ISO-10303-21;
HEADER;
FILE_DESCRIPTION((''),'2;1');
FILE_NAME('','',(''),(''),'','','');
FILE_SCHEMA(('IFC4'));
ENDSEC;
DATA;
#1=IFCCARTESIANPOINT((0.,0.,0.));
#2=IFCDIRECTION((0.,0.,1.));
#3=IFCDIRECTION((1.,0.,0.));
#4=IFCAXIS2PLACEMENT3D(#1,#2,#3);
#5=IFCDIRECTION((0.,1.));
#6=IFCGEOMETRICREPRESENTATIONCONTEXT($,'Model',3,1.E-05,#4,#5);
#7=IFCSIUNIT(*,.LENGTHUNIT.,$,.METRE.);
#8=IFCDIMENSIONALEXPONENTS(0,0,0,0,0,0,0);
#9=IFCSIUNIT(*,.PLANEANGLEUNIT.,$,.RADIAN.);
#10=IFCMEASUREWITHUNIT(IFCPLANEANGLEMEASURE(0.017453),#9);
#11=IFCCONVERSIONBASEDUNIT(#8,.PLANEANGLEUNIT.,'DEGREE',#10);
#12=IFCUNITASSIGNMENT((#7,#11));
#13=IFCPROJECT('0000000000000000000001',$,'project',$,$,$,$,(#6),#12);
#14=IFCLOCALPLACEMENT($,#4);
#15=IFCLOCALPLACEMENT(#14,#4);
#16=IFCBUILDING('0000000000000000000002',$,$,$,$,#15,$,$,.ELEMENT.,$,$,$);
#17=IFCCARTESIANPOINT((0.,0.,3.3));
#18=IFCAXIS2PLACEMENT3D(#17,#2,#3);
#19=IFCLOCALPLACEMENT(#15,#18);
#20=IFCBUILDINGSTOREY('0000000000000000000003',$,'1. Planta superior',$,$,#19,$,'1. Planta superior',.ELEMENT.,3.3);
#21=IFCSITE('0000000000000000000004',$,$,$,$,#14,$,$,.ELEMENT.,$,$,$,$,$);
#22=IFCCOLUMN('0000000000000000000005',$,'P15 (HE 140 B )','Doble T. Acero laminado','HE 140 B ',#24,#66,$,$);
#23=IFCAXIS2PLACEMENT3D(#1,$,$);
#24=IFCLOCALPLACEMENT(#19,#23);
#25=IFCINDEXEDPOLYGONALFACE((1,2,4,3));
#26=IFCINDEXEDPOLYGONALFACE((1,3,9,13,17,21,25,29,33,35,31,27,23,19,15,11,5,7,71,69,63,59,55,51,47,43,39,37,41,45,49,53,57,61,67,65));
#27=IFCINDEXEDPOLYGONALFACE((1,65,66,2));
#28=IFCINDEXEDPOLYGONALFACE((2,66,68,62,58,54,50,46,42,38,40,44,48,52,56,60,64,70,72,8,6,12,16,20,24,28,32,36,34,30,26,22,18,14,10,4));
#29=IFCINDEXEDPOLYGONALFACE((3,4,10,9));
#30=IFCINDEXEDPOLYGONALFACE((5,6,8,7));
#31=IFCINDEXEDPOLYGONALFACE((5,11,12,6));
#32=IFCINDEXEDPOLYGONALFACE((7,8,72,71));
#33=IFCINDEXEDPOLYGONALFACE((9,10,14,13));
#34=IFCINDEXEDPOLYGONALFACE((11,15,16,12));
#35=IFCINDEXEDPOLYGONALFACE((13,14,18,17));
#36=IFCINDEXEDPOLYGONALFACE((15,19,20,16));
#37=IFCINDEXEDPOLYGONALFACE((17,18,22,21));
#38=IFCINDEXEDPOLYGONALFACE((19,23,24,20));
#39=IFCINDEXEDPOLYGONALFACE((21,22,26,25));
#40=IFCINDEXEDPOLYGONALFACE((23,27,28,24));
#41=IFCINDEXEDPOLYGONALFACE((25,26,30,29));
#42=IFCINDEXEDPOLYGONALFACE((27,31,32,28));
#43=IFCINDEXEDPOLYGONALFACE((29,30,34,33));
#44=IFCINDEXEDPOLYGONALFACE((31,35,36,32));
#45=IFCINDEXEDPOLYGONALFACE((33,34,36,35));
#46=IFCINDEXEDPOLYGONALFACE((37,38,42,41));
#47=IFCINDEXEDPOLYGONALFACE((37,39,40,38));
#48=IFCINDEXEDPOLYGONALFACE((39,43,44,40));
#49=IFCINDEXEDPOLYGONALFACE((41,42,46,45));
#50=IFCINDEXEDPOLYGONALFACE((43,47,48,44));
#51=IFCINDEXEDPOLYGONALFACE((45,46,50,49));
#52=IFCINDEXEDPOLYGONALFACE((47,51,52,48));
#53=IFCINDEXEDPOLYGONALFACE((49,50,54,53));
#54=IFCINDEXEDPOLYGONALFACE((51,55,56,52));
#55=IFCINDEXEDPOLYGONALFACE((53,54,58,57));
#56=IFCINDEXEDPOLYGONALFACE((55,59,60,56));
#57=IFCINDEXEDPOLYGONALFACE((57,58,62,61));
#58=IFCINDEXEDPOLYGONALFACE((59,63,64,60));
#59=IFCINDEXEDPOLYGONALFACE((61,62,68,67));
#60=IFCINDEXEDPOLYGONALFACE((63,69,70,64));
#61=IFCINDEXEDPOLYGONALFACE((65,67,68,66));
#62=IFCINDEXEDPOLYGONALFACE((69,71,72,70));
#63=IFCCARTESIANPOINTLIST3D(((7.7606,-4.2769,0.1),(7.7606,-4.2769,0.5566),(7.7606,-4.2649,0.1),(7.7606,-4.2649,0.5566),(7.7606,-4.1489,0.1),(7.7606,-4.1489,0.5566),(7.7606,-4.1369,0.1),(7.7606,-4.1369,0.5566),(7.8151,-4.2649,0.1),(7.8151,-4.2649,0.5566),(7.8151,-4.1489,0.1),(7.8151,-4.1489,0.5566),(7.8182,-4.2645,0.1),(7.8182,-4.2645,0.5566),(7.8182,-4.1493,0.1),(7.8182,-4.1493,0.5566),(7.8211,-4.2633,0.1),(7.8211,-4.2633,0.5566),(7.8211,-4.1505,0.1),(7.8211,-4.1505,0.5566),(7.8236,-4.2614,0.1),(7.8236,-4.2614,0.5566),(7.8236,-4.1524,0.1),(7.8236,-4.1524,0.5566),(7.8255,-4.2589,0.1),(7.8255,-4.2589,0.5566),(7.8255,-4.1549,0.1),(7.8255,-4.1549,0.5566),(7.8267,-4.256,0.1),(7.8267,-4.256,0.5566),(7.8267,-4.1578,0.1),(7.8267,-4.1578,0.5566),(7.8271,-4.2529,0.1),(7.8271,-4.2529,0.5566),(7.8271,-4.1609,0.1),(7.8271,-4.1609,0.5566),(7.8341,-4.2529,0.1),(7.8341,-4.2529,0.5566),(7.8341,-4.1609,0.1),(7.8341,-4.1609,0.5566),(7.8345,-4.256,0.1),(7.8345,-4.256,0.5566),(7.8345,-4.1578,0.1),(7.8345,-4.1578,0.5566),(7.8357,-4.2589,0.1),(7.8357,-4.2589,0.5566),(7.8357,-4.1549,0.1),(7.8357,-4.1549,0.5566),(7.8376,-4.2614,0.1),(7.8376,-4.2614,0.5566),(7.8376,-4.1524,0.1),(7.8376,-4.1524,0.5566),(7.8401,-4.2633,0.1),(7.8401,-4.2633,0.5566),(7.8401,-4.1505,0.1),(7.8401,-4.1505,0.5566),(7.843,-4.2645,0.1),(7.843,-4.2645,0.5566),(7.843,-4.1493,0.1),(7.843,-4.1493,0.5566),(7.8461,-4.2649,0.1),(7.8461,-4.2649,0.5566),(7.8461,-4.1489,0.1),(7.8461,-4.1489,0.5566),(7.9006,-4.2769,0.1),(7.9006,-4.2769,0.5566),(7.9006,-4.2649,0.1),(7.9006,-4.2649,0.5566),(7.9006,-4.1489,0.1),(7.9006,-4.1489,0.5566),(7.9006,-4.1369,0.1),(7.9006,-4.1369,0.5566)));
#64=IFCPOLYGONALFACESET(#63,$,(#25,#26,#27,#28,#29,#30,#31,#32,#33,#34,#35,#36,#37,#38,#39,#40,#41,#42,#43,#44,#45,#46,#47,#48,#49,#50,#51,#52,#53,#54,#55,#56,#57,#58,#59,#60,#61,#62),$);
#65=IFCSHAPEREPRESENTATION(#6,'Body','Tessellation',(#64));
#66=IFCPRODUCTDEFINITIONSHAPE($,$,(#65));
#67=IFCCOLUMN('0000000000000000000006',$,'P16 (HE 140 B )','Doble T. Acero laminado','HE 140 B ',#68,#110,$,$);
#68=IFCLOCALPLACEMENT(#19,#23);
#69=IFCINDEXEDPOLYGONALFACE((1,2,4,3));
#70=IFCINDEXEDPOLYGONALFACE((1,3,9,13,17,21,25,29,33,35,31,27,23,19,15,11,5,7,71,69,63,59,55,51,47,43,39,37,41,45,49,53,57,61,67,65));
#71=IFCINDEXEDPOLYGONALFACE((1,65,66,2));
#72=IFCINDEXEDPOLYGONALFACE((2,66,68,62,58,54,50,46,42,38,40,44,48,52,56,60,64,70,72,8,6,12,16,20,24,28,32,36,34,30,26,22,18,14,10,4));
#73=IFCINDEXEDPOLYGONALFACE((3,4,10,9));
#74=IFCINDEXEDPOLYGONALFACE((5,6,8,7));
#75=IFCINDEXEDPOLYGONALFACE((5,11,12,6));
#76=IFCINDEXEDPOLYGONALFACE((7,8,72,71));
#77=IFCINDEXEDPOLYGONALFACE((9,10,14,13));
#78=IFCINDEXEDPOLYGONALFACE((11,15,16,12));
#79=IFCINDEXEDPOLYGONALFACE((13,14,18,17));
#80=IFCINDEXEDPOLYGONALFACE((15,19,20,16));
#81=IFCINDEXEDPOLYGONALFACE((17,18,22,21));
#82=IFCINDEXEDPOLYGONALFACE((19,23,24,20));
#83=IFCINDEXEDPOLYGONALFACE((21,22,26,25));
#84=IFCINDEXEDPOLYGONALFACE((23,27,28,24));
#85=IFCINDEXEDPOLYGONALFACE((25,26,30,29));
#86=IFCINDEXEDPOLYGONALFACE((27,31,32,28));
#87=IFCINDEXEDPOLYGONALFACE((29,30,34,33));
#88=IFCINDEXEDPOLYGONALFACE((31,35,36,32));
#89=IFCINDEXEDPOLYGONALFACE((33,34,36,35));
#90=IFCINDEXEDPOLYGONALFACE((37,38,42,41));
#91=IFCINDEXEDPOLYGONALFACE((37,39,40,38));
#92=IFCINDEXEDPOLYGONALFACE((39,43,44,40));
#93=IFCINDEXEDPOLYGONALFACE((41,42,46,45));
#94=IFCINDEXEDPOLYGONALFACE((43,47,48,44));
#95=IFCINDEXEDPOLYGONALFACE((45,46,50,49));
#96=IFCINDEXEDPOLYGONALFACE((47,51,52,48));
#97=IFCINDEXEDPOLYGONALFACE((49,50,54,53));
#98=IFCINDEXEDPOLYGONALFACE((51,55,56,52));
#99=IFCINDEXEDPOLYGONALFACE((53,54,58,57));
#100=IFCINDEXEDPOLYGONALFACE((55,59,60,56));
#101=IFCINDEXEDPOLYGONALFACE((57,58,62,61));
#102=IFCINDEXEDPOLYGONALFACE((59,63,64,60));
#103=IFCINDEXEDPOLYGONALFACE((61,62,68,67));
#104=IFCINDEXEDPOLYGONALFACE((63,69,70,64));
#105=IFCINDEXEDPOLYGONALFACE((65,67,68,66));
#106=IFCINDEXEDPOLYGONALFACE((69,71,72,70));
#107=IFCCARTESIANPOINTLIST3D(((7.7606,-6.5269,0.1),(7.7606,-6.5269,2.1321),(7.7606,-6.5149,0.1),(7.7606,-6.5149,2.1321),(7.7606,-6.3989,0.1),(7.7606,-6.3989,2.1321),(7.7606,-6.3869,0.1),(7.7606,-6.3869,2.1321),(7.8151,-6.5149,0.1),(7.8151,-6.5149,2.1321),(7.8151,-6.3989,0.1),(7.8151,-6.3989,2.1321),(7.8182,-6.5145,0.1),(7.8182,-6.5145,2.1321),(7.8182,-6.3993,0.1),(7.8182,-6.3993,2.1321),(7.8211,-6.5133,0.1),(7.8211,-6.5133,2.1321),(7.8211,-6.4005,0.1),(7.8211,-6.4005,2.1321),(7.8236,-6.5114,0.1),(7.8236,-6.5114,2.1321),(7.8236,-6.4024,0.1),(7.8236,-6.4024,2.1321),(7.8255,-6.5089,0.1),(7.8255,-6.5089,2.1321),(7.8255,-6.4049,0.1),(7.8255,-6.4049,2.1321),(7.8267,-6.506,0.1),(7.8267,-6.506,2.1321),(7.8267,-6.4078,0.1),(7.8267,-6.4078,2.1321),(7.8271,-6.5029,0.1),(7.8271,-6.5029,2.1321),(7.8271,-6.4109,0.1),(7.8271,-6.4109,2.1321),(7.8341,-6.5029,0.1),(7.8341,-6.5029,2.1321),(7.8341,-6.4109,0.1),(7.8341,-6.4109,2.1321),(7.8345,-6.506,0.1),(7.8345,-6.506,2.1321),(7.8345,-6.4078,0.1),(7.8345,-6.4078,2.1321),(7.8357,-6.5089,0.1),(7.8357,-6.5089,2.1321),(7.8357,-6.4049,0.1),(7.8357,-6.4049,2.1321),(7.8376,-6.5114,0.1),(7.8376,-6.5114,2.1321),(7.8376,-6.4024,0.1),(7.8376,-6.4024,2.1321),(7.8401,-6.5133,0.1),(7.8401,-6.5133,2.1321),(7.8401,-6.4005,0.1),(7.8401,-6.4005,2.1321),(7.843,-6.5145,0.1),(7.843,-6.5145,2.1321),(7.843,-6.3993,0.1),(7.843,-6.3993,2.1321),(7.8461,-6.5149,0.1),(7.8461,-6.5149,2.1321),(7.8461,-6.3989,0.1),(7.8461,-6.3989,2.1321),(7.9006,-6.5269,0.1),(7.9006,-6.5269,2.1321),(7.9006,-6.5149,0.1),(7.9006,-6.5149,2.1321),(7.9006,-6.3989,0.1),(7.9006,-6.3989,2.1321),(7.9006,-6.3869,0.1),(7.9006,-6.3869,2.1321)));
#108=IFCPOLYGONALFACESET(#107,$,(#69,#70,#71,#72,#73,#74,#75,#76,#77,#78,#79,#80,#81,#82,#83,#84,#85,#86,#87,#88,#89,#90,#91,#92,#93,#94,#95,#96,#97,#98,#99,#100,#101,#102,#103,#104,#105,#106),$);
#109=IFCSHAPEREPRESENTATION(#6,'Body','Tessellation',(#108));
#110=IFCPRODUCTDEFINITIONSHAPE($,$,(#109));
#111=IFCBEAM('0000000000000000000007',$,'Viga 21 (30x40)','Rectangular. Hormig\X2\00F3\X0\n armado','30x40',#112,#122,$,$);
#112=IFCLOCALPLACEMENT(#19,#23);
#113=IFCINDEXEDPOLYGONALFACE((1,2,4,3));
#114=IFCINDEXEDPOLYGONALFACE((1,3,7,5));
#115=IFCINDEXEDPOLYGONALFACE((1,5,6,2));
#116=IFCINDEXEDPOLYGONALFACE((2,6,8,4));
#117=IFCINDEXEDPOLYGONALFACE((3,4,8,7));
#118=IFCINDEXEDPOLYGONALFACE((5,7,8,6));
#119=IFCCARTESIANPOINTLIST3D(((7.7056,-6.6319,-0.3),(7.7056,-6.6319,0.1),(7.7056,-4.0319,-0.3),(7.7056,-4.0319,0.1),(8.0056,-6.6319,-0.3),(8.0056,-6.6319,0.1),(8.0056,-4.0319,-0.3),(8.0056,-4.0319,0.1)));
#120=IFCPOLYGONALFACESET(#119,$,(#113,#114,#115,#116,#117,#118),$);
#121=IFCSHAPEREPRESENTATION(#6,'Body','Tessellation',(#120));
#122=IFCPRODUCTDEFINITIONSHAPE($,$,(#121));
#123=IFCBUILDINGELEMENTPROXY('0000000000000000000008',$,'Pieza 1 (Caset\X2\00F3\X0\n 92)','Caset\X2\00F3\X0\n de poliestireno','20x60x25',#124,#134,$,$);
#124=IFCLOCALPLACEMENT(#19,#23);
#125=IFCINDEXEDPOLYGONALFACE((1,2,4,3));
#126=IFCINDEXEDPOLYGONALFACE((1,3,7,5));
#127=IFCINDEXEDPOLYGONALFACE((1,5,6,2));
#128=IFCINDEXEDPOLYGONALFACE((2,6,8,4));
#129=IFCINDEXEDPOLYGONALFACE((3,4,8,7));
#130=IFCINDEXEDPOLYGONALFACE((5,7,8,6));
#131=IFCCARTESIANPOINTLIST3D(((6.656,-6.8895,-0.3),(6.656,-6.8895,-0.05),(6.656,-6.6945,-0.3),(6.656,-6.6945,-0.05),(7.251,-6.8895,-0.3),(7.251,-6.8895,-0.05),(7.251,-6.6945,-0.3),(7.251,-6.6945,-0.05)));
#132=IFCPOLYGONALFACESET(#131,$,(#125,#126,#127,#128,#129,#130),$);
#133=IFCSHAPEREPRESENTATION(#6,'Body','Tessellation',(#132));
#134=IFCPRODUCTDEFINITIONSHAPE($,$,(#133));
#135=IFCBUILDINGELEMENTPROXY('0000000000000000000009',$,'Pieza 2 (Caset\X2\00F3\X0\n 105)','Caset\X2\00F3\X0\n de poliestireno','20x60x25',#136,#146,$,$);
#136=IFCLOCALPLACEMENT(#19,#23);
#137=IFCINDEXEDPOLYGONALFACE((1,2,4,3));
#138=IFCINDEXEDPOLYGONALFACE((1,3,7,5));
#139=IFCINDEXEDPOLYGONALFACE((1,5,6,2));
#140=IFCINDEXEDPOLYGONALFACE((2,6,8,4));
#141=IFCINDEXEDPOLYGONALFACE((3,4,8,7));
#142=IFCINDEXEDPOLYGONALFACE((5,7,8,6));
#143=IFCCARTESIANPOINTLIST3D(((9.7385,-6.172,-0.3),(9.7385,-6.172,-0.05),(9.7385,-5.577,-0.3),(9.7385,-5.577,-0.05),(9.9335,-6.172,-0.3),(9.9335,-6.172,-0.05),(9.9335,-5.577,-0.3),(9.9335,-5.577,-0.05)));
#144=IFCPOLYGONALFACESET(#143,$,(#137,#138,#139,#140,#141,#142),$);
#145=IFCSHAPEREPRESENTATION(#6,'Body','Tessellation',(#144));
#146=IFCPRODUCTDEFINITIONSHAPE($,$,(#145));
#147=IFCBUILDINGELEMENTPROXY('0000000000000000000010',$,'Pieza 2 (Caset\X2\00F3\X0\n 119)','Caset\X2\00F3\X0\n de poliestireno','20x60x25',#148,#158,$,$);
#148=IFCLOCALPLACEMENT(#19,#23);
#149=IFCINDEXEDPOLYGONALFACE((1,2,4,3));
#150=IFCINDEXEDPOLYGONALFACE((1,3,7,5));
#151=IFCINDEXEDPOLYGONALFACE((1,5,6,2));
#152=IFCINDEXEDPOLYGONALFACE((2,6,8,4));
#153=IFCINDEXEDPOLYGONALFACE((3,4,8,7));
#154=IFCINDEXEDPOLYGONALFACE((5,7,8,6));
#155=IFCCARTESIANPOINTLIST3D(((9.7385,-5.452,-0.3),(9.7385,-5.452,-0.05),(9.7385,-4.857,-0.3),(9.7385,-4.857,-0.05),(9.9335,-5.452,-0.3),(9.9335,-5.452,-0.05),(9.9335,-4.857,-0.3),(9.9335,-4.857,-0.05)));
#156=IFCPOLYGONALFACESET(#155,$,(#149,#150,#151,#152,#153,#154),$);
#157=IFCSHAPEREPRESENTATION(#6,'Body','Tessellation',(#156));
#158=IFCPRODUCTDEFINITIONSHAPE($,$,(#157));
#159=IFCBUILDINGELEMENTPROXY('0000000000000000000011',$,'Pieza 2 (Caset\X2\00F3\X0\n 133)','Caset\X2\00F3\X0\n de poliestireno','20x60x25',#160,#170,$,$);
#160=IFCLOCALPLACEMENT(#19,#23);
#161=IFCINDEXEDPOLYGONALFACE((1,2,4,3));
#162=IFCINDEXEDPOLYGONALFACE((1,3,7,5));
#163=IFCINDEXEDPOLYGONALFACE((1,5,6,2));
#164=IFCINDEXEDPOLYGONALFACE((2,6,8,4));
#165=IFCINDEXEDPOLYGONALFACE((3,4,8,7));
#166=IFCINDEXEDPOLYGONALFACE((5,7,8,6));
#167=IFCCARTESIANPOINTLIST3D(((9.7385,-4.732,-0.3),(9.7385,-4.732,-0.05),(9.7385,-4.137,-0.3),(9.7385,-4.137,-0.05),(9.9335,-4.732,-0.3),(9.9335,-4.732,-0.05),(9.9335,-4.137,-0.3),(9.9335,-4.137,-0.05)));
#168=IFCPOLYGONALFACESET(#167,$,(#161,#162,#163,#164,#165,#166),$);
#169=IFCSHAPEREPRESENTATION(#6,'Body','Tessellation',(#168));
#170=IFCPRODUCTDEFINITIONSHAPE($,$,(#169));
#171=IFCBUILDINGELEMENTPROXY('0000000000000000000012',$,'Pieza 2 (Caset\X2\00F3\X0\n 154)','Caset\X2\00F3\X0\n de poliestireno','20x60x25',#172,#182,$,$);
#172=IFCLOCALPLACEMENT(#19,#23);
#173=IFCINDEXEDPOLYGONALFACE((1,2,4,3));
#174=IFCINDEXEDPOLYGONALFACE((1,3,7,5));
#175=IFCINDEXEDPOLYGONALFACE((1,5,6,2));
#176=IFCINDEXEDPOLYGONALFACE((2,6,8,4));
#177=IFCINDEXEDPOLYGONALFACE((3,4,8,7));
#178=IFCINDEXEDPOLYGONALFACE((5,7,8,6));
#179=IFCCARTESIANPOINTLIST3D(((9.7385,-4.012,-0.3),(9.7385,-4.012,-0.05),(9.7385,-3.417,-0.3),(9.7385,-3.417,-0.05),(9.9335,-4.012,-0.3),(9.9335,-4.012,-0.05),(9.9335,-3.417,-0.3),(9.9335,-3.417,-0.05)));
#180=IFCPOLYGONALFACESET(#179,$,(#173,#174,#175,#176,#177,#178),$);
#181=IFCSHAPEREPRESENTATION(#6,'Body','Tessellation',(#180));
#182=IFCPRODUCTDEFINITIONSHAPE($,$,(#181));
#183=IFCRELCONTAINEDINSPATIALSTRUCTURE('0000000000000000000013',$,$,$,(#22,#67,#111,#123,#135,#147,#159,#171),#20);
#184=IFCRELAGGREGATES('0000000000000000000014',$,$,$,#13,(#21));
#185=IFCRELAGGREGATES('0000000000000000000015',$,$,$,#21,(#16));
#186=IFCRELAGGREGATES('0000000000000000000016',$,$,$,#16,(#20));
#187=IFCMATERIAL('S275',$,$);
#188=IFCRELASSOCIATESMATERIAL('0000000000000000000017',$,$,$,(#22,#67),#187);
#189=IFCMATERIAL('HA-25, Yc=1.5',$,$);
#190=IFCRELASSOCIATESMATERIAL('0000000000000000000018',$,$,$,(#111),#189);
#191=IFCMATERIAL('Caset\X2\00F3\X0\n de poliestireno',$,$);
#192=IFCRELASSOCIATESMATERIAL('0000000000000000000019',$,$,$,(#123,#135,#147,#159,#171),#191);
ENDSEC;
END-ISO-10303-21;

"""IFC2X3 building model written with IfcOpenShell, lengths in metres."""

from ifc_helpers import new_model, entity, si_unit, converted_unit, direction, frame, frame_2d, origin_with_axes, origin_2d_with_axis, place, context, project, spatial, rectangle, i_section, extrude, source, transform, mapped, material, element, save


model = new_model("IFC2X3")

# Units and contexts
model_context = context("Model", 3, precision=1e-05, world=origin_with_axes(), true_north=direction((0.0, 1.0)))
ifc_project = project(units=[si_unit("LENGTHUNIT", "METRE"), converted_unit("PLANEANGLEUNIT", "DEGREE", entity("IfcPlaneAngleMeasure", 0.017453), si_unit("PLANEANGLEUNIT", "RADIAN"), dimensions=[0, 0, 0, 0, 0, 0, 0])], contexts=[model_context])

# Site, building, storey
site_placement = place(None, origin_with_axes())
site = spatial("IfcSite", under=ifc_project, at=site_placement, CompositionType="ELEMENT")
building_placement = place(site_placement, origin_with_axes())
building = spatial("IfcBuilding", under=site, at=building_placement, CompositionType="ELEMENT")
storey_placement = place(building_placement, frame((0.0, 0.0, 3.3), z_axis=(0.0, 0.0, 1.0), x_axis=(1.0, 0.0, 0.0)))
storey = spatial("IfcBuildingStorey", under=building, at=storey_placement, Name="1. Planta superior", LongName="1. Planta superior", CompositionType="ELEMENT", Elevation=3.3)

# Columns
ifc_material_1 = material(Name="S275")
column_1_placement = place(storey_placement, frame((7.8306, -4.2069, 0.1), z_axis=(0.0, 0.0, 1.0), x_axis=(1.0, 0.0, 0.0)))
element("IfcColumn", 1, at=column_1_placement, inside=storey, material=ifc_material_1, Name="P15 (HE 140 B )", Description="Doble T. Acero laminado", ObjectType="HE 140 B ", context=model_context, shape_type="SweptSolid", body=[
    extrude(i_section(OverallWidth=0.14, OverallDepth=0.14, WebThickness=0.007, FlangeThickness=0.012, FilletRadius=0.012, at=origin_2d_with_axis()), origin_with_axes(), (0.0, 0.0, 1.0), 0.4566),
])
column_2_placement = place(storey_placement, frame((7.8306, -6.4569, 0.1), z_axis=(0.0, 0.0, 1.0), x_axis=(1.0, 0.0, 0.0)))
element("IfcColumn", 2, at=column_2_placement, inside=storey, material=ifc_material_1, Name="P16 (HE 140 B )", Description="Doble T. Acero laminado", ObjectType="HE 140 B ", context=model_context, shape_type="SweptSolid", body=[
    extrude(i_section(OverallWidth=0.14, OverallDepth=0.14, WebThickness=0.007, FlangeThickness=0.012, FilletRadius=0.012, at=origin_2d_with_axis()), origin_with_axes(), (0.0, 0.0, 1.0), 2.0321),
])

# Beam
ifc_material_2 = material(Name="HA-25, Yc=1.5")
beam_placement = place(storey_placement, frame((7.8556, -6.6319, 0.1), z_axis=(0.0, 1.0, 0.0), x_axis=(-1.0, 0.0, 0.0)))
element("IfcBeam", 3, at=beam_placement, inside=storey, material=ifc_material_2, Name="Viga 21 (30x40)", Description="Rectangular. Hormigón armado", ObjectType="30x40", context=model_context, shape_type="SweptSolid", body=[
    extrude(rectangle(XDim=0.3, YDim=0.4, at=frame_2d((0.0, -0.2), x_axis=(1.0, 0.0))), origin_with_axes(), (0.0, 0.0, 1.0), 2.6),
])

# Building element proxies
ifc_material_3 = material(Name="Casetón de poliestireno")
shared_shape = source(origin_with_axes(), model_context, "Body", "SweptSolid", [
    extrude(rectangle(XDim=0.195, YDim=0.25, at=origin_2d_with_axis()), origin_with_axes(), (0.0, 0.0, 1.0), 0.595),
])
placement_1 = place(storey_placement, frame((6.656, -6.792, -0.175), z_axis=(1.0, 0.0, 0.0), x_axis=(0.0, 1.0, 0.0)))
proxy_placement = place(placement_1, origin_with_axes())
element("IfcBuildingElementProxy", 4, at=proxy_placement, inside=storey, material=ifc_material_3, Name="Pieza 1 (Casetón 92)", Description="Casetón de poliestireno", ObjectType="20x60x25", context=model_context, shape_type="MappedRepresentation", body=[
    mapped(shared_shape, transform((0.0, 0.0, 0.0), x_axis=(1.0, 0.0, 0.0), y_axis=(0.0, 1.0, 0.0), z_axis=(0.0, 0.0, 1.0))),
])
placement_2 = place(storey_placement, frame((9.836, -6.172, -0.175), z_axis=(0.0, 1.0, 0.0), x_axis=(-1.0, 0.0, 0.0)))
for number, where, z_axis, x_axis, name in (
    (5, (0.0, 0.0, 0.0), (0.0, 0.0, 1.0), (1.0, 0.0, 0.0), "Pieza 2 (Casetón 105)"),
):
    element("IfcBuildingElementProxy", number, at=place(placement_2, frame(where, z_axis=z_axis, x_axis=x_axis)), inside=storey, material=ifc_material_3, Name=name, Description="Casetón de poliestireno", ObjectType="20x60x25", context=model_context, shape_type="MappedRepresentation", body=[
        mapped(shared_shape, transform((0.0, 0.0, 0.0), x_axis=(1.0, 0.0, 0.0), y_axis=(0.0, 1.0, 0.0), z_axis=(0.0, 0.0, 1.0))),
    ])
placement_3 = place(storey_placement, frame((9.836, -5.452, -0.175), z_axis=(0.0, 1.0, 0.0), x_axis=(-1.0, 0.0, 0.0)))
for number, where, z_axis, x_axis, name in (
    (6, (0.0, 0.0, 0.0), (0.0, 0.0, 1.0), (1.0, 0.0, 0.0), "Pieza 2 (Casetón 119)"),
):
    element("IfcBuildingElementProxy", number, at=place(placement_3, frame(where, z_axis=z_axis, x_axis=x_axis)), inside=storey, material=ifc_material_3, Name=name, Description="Casetón de poliestireno", ObjectType="20x60x25", context=model_context, shape_type="MappedRepresentation", body=[
        mapped(shared_shape, transform((0.0, 0.0, 0.0), x_axis=(1.0, 0.0, 0.0), y_axis=(0.0, 1.0, 0.0), z_axis=(0.0, 0.0, 1.0))),
    ])
placement_4 = place(storey_placement, frame((9.836, -4.732, -0.175), z_axis=(0.0, 1.0, 0.0), x_axis=(-1.0, 0.0, 0.0)))
for number, where, z_axis, x_axis, name in (
    (7, (0.0, 0.0, 0.0), (0.0, 0.0, 1.0), (1.0, 0.0, 0.0), "Pieza 2 (Casetón 133)"),
):
    element("IfcBuildingElementProxy", number, at=place(placement_4, frame(where, z_axis=z_axis, x_axis=x_axis)), inside=storey, material=ifc_material_3, Name=name, Description="Casetón de poliestireno", ObjectType="20x60x25", context=model_context, shape_type="MappedRepresentation", body=[
        mapped(shared_shape, transform((0.0, 0.0, 0.0), x_axis=(1.0, 0.0, 0.0), y_axis=(0.0, 1.0, 0.0), z_axis=(0.0, 0.0, 1.0))),
    ])
placement_5 = place(storey_placement, frame((9.836, -4.012, -0.175), z_axis=(0.0, 1.0, 0.0), x_axis=(-1.0, 0.0, 0.0)))
for number, where, z_axis, x_axis, name in (
    (8, (0.0, 0.0, 0.0), (0.0, 0.0, 1.0), (1.0, 0.0, 0.0), "Pieza 2 (Casetón 154)"),
):
    element("IfcBuildingElementProxy", number, at=place(placement_5, frame(where, z_axis=z_axis, x_axis=x_axis)), inside=storey, material=ifc_material_3, Name=name, Description="Casetón de poliestireno", ObjectType="20x60x25", context=model_context, shape_type="MappedRepresentation", body=[
        mapped(shared_shape, transform((0.0, 0.0, 0.0), x_axis=(1.0, 0.0, 0.0), y_axis=(0.0, 1.0, 0.0), z_axis=(0.0, 0.0, 1.0))),
    ])

save(model, "model.ifc")
